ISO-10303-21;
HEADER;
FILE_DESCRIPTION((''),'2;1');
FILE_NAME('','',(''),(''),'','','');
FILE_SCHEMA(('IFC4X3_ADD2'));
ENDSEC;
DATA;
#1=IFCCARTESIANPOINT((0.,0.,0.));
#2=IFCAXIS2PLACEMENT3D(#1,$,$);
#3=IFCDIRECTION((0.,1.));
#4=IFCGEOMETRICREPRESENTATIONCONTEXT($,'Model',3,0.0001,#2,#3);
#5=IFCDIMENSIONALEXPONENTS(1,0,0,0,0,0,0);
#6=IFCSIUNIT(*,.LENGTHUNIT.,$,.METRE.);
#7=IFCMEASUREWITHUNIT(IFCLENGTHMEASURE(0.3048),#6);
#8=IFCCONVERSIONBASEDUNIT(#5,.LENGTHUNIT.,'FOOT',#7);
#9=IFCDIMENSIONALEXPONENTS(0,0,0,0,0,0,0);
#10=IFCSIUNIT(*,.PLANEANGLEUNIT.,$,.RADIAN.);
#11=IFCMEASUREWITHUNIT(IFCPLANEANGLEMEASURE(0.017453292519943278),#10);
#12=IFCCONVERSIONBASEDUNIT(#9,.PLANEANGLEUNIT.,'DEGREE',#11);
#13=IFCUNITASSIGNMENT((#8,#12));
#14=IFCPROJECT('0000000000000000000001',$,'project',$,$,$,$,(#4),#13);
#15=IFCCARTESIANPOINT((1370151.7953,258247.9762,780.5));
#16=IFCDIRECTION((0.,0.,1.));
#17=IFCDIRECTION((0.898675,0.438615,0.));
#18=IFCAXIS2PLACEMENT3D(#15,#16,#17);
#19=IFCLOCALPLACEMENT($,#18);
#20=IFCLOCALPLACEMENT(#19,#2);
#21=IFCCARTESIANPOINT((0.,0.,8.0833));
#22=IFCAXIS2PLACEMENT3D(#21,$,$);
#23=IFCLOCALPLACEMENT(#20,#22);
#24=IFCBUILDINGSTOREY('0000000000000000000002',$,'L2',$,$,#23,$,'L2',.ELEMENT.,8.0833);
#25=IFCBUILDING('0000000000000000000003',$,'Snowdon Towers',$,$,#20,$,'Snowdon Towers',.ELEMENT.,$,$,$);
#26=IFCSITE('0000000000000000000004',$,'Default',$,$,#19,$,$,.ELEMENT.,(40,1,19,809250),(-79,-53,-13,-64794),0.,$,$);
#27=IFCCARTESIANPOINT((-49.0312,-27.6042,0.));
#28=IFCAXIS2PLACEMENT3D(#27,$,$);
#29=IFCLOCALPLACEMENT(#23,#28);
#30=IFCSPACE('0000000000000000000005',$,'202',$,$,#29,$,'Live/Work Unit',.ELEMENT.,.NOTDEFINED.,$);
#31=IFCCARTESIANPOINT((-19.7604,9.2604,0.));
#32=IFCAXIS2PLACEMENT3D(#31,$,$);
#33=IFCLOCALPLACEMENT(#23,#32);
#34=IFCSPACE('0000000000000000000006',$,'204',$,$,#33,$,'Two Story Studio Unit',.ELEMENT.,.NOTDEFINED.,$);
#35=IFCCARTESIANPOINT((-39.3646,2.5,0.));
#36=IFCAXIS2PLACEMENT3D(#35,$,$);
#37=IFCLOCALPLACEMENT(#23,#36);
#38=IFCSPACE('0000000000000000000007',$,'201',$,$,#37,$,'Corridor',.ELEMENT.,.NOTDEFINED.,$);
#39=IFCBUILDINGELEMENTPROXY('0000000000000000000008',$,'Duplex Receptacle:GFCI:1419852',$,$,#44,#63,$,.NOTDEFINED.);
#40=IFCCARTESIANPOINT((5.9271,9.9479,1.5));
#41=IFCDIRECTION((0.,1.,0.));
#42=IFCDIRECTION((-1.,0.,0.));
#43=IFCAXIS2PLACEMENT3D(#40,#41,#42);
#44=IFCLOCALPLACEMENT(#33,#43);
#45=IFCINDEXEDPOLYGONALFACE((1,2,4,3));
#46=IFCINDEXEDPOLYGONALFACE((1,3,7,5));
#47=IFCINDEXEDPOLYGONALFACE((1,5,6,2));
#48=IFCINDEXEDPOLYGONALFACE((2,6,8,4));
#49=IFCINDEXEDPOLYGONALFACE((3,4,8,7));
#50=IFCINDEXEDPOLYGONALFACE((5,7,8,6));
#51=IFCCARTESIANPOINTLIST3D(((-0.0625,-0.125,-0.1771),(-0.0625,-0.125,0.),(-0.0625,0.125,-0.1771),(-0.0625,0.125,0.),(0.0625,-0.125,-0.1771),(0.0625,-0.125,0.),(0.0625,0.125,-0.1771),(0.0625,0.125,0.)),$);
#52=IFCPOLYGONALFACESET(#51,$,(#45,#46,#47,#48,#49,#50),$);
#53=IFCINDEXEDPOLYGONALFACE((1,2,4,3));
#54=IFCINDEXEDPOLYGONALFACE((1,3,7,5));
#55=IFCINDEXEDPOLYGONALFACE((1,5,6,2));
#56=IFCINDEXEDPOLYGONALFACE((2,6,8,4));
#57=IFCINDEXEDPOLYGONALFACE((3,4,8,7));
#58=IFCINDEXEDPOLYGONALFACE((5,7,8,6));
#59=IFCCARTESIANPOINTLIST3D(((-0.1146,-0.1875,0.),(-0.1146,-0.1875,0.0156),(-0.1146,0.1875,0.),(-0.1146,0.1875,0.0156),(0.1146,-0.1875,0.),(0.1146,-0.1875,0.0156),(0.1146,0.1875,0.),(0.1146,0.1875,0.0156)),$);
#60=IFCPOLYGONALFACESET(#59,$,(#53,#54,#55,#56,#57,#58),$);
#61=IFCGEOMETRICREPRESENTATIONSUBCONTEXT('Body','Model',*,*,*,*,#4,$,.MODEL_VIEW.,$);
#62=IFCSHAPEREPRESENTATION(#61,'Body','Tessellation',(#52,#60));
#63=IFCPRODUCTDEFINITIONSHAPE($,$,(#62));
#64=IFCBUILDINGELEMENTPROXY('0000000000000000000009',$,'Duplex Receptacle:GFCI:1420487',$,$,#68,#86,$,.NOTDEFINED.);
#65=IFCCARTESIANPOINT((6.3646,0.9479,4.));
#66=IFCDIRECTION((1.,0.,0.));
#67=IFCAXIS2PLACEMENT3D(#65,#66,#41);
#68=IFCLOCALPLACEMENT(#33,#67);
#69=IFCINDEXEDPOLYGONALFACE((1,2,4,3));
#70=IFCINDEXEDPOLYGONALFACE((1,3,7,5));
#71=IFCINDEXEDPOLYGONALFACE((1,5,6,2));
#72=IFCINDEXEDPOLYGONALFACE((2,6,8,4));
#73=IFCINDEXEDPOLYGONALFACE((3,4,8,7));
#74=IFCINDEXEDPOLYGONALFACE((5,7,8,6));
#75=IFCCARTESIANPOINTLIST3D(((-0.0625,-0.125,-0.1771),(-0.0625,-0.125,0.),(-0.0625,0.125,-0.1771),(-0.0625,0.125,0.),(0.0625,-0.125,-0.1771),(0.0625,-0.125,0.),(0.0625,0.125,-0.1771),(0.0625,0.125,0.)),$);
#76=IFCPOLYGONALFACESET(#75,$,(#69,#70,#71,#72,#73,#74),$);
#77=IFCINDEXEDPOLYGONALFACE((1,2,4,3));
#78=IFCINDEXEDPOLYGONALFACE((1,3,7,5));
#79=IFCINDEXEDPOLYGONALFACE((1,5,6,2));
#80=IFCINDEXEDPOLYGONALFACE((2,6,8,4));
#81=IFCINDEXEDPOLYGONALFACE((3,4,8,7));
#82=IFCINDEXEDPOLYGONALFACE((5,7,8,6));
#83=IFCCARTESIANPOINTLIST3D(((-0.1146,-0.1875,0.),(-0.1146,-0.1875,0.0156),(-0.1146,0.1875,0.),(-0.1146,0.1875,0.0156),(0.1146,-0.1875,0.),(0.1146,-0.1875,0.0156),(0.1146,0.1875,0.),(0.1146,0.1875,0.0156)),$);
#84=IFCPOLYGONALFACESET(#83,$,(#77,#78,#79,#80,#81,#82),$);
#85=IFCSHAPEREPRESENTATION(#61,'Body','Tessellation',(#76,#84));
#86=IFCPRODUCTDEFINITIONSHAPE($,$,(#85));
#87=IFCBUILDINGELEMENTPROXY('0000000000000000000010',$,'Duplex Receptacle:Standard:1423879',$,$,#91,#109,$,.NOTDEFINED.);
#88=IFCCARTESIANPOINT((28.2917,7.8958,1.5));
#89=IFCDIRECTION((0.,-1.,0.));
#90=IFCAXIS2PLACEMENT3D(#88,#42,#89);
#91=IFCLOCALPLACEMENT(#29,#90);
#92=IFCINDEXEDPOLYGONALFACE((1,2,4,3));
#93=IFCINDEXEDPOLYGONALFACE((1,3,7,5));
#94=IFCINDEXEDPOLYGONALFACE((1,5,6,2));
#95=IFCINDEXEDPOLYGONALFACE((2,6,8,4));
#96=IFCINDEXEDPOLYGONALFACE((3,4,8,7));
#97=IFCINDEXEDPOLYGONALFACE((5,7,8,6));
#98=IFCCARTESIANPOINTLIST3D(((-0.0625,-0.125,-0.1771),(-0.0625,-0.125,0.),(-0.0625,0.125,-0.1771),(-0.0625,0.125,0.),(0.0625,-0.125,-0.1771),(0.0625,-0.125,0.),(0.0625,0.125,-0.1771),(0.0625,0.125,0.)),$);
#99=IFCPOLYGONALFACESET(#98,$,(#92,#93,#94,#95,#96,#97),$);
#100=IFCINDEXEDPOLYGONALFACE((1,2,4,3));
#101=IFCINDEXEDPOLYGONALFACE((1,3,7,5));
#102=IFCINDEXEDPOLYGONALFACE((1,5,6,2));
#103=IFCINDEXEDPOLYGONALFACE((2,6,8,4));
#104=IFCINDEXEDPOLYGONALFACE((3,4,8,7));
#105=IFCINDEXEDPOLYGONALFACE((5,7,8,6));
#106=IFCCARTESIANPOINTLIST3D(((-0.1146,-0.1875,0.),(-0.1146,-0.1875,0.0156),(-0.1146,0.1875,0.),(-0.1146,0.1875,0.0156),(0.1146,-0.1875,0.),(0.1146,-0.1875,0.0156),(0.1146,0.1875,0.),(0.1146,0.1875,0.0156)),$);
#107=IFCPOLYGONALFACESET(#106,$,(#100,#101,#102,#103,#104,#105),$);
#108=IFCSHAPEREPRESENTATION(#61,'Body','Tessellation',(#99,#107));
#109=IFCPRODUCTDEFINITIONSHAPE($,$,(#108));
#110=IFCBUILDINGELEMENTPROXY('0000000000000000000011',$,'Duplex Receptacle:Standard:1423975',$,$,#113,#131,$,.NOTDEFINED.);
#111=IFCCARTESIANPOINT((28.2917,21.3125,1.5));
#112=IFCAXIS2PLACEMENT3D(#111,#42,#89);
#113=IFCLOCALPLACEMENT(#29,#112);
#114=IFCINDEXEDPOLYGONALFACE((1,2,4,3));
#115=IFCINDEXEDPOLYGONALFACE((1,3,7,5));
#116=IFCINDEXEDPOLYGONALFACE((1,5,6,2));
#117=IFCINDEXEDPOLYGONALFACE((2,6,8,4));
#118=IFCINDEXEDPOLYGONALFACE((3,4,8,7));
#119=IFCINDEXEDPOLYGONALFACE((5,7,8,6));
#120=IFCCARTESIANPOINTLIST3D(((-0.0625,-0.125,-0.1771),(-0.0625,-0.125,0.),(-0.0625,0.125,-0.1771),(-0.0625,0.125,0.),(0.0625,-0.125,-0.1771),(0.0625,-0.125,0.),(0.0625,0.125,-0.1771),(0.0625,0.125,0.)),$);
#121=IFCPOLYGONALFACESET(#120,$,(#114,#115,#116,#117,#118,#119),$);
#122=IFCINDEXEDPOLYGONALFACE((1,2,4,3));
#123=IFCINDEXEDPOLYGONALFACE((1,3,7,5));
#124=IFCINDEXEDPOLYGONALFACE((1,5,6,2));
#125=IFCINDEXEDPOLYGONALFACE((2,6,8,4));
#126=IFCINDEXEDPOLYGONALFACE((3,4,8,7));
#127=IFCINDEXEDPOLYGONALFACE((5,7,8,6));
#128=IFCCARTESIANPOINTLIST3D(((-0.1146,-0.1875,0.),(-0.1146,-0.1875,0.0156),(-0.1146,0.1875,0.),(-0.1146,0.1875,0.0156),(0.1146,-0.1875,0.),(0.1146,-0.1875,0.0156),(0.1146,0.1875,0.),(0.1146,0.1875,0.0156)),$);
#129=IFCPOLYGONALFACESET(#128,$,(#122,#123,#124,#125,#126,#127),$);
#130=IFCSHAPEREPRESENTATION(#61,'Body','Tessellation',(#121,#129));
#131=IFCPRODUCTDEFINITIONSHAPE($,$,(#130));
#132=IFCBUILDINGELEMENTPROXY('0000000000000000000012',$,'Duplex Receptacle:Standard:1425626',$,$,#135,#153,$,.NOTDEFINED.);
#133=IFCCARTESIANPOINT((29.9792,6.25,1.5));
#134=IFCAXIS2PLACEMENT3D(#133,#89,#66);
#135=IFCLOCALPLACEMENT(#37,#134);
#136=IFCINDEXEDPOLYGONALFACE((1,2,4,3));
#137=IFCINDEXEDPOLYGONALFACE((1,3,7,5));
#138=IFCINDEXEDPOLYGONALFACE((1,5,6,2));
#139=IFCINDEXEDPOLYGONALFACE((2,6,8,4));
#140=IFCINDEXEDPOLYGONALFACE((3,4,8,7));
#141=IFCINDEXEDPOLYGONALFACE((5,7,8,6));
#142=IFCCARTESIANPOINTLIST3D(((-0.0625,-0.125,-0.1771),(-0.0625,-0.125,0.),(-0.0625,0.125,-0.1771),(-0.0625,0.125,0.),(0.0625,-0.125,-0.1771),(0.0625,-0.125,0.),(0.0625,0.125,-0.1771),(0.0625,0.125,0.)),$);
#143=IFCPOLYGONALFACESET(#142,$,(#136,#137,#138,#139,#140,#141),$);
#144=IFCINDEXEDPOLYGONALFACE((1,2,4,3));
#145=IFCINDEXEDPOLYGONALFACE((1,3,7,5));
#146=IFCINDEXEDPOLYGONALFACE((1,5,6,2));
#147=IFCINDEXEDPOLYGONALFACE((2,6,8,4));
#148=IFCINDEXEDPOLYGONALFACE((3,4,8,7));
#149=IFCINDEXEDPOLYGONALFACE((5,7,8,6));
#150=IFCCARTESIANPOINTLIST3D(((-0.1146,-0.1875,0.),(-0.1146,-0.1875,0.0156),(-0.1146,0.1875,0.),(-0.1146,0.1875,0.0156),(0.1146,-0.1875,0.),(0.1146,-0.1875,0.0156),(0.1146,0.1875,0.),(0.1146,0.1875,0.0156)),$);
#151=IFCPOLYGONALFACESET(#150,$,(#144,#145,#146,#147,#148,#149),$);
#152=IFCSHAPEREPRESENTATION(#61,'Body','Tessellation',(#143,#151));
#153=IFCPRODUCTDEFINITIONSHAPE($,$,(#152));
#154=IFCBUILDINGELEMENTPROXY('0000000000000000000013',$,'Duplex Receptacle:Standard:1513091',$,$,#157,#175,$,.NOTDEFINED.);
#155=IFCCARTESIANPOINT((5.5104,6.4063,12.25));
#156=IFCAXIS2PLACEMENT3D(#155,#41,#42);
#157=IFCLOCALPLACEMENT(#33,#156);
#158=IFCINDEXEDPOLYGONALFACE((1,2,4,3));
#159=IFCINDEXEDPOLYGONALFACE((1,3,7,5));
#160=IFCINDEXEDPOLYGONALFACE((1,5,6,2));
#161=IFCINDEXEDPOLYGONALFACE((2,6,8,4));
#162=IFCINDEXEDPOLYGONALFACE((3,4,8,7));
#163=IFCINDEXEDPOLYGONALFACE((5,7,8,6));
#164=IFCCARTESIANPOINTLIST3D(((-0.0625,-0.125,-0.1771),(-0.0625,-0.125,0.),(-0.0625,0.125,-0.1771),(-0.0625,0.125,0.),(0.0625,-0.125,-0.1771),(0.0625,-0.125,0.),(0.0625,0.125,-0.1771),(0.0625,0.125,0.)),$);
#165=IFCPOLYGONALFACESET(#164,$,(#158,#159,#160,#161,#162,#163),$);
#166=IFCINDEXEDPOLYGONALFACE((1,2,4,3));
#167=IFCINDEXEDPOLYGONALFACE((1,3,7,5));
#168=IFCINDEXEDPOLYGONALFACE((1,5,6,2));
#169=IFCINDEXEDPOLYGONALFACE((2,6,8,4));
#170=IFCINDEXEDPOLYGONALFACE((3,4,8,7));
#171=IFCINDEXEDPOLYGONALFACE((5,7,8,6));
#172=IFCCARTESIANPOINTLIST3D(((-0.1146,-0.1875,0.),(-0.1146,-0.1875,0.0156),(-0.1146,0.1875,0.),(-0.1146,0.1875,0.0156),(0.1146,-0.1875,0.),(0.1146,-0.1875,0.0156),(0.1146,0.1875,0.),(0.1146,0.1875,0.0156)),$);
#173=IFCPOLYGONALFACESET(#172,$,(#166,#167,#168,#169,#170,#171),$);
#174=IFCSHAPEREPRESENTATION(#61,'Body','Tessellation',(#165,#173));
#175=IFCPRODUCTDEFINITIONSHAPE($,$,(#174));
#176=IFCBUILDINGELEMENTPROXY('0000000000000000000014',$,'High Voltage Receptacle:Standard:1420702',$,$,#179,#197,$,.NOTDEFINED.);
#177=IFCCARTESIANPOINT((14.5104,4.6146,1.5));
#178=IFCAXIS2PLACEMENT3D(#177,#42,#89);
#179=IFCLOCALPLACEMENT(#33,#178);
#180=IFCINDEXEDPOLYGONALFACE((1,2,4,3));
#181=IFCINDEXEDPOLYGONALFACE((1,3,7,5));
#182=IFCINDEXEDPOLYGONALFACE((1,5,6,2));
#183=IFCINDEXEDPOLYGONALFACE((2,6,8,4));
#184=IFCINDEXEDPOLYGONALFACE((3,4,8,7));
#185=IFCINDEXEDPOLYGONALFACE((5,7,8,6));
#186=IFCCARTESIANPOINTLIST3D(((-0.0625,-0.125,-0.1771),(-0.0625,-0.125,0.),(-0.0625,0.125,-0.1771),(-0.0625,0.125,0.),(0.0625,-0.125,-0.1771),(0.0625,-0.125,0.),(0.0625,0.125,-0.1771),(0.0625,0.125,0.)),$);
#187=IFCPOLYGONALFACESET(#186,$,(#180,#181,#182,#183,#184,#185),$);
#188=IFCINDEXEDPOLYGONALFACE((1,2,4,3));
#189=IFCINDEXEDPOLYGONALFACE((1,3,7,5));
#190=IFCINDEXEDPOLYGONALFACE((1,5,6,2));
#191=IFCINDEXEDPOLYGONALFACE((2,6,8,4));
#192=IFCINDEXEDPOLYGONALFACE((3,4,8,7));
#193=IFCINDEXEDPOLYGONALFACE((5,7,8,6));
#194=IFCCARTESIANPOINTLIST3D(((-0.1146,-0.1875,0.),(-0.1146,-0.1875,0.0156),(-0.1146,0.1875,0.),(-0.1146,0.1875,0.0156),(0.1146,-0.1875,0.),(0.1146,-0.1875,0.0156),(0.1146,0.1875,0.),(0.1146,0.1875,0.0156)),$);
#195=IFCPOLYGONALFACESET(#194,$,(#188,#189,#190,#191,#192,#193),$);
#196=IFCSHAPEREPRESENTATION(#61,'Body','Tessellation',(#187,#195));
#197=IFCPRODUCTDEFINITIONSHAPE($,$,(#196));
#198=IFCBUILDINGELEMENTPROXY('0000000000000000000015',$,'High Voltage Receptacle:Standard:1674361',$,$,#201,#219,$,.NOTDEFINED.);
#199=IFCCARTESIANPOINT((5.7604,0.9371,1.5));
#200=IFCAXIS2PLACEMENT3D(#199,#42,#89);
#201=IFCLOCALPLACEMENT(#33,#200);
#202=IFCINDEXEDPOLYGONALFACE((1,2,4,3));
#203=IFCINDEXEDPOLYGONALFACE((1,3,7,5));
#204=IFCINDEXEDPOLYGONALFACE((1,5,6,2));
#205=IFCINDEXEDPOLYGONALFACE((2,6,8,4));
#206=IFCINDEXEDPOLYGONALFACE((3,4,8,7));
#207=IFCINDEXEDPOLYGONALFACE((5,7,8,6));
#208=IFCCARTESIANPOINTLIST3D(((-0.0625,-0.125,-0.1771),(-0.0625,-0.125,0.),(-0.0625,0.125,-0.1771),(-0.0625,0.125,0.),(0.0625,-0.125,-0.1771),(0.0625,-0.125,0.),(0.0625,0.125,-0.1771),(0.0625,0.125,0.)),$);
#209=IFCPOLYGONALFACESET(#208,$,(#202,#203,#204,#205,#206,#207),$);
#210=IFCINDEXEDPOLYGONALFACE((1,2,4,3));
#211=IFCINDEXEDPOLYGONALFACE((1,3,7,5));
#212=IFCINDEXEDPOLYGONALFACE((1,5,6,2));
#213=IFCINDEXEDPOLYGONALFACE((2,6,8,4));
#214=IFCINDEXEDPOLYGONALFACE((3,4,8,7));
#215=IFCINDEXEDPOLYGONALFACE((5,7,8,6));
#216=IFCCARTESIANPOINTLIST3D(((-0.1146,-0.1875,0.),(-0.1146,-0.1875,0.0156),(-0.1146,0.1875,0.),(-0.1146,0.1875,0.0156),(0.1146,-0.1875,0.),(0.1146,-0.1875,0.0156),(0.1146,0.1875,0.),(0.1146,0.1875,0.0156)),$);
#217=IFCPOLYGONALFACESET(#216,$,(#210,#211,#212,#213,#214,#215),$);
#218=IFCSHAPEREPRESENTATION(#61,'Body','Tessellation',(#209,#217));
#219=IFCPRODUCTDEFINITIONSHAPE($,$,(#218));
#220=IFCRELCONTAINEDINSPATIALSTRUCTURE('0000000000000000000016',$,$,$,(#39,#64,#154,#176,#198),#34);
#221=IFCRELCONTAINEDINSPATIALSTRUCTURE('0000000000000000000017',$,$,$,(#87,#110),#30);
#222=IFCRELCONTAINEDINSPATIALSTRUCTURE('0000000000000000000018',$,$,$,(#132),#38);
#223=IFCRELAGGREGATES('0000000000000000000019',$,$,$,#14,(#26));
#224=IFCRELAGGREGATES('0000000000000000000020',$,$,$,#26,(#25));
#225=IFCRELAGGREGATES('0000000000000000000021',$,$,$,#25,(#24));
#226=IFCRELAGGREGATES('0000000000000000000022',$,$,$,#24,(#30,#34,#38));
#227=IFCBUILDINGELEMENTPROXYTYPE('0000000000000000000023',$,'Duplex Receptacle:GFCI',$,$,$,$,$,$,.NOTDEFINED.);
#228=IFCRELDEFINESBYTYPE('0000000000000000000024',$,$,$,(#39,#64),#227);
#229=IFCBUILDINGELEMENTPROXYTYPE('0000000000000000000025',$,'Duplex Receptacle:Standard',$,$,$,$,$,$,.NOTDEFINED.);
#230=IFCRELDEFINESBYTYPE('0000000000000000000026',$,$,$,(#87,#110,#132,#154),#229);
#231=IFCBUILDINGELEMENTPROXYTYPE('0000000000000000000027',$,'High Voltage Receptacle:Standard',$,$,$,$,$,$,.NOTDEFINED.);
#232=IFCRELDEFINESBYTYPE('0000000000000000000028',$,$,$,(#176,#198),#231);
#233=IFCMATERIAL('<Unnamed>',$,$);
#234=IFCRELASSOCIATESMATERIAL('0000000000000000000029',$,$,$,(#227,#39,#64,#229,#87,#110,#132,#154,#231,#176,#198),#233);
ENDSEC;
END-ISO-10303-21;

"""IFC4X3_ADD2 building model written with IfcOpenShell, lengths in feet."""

from ifc_helpers import new_model, entity, si_unit, converted_unit, direction, frame, frame_2d, origin, origin_2d_with_axis, place, context, subcontext, project, spatial, rectangle, extrude, source, transform, mapped, material, type_object, type_shapes, element, save


model = new_model("IFC4X3_ADD2")

# Units and contexts
model_context = context("Model", 3, precision=0.0001, world=origin(), true_north=direction((0.0, 1.0)))
body_context = subcontext(model_context, "Body", "Model", "MODEL_VIEW")
ifc_project = project(units=[converted_unit("LENGTHUNIT", "FOOT", entity("IfcLengthMeasure", 0.3048), si_unit("LENGTHUNIT", "METRE"), dimensions=[1, 0, 0, 0, 0, 0, 0]), converted_unit("PLANEANGLEUNIT", "DEGREE", entity("IfcPlaneAngleMeasure", 0.017453292519943278), si_unit("PLANEANGLEUNIT", "RADIAN"), dimensions=[0, 0, 0, 0, 0, 0, 0])], contexts=[model_context])

# Site, building, storey, space
site_placement = place(None, frame((1370151.7953, 258247.9762, 780.5), z_axis=(0.0, 0.0, 1.0), x_axis=(0.898675, 0.438615, 0.0)))
site = spatial("IfcSite", under=ifc_project, at=site_placement, Name="Default", CompositionType="ELEMENT", RefLatitude=(40, 1, 19, 809250), RefLongitude=(-79, -53, -13, -64794), RefElevation=0.0)
building_placement = place(site_placement, origin())
building = spatial("IfcBuilding", under=site, at=building_placement, Name="Snowdon Towers", LongName="Snowdon Towers", CompositionType="ELEMENT")
storey_placement = place(building_placement, frame((0.0, 0.0, 8.0833)))
storey = spatial("IfcBuildingStorey", under=building, at=storey_placement, Name="L2", LongName="L2", CompositionType="ELEMENT", Elevation=8.0833)
space_1_placement = place(storey_placement, frame((-49.0312, -27.6042, 0.0)))
space_1 = spatial("IfcSpace", under=storey, at=space_1_placement, Name="202", LongName="Live/Work Unit", CompositionType="ELEMENT", PredefinedType="NOTDEFINED")

# Shared definitions
ifc_material_1 = material(Name="<Unnamed>")

# Shared definitions
space_2_placement = place(storey_placement, frame((-19.7604, 9.2604, 0.0)))
space_2 = spatial("IfcSpace", under=storey, at=space_2_placement, Name="204", LongName="Two Story Studio Unit", CompositionType="ELEMENT", PredefinedType="NOTDEFINED")

# Building element proxies
building_element_proxy_type_1 = type_object("IfcBuildingElementProxyType", Name="Duplex Receptacle:GFCI", PredefinedType="NOTDEFINED", material=ifc_material_1)
shared_shape_1 = source(origin(), body_context, "Body", "SweptSolid", [
    extrude(rectangle(XDim=0.125, YDim=0.25, at=origin_2d_with_axis()), frame((0.0, 0.0, -0.1771), z_axis=(0.0, 0.0, 1.0), x_axis=(-1.0, 0.0, 0.0)), (0.0, 0.0, 1.0), 0.1771),
    extrude(rectangle(XDim=0.2292, YDim=0.375, at=frame_2d((0.0, 0.0), x_axis=(1.0, 0.0))), frame((0.0, 0.0, 0.0), z_axis=(0.0, 0.0, 1.0), x_axis=(-1.0, 0.0, 0.0)), (0.0, 0.0, 1.0), 0.0156),
])
type_shapes(building_element_proxy_type_1, [shared_shape_1])
for number, where, z_axis, x_axis, name in (
    (1, (5.9271, 9.9479, 1.5), (0.0, 1.0, 0.0), (-1.0, 0.0, 0.0), "Duplex Receptacle:GFCI:1419852"),
    (2, (6.3646, 0.9479, 4.0), (1.0, 0.0, 0.0), (0.0, 1.0, 0.0), "Duplex Receptacle:GFCI:1420487"),
):
    element("IfcBuildingElementProxy", number, at=place(space_2_placement, frame(where, z_axis=z_axis, x_axis=x_axis)), inside=space_2, type_object=building_element_proxy_type_1, material=ifc_material_1, Name=name, PredefinedType="NOTDEFINED", context=body_context, shape_type="MappedRepresentation", body=[
        mapped(shared_shape_1, transform((0.0, 0.0, 0.0), scale=1.0)),
    ])
building_element_proxy_type_2 = type_object("IfcBuildingElementProxyType", Name="Duplex Receptacle:Standard", PredefinedType="NOTDEFINED", material=ifc_material_1)
shared_shape_2 = source(origin(), body_context, "Body", "SweptSolid", [
    extrude(rectangle(XDim=0.125, YDim=0.25, at=origin_2d_with_axis()), frame((0.0, 0.0, -0.1771), z_axis=(0.0, 0.0, 1.0), x_axis=(-1.0, 0.0, 0.0)), (0.0, 0.0, 1.0), 0.1771),
    extrude(rectangle(XDim=0.2292, YDim=0.375, at=frame_2d((0.0, 0.0), x_axis=(1.0, 0.0))), frame((0.0, 0.0, 0.0), z_axis=(0.0, 0.0, 1.0), x_axis=(-1.0, 0.0, 0.0)), (0.0, 0.0, 1.0), 0.0156),
])
type_shapes(building_element_proxy_type_2, [shared_shape_2])
for number, where, z_axis, x_axis, name in (
    (3, (28.2917, 7.8958, 1.5), (-1.0, 0.0, 0.0), (0.0, -1.0, 0.0), "Duplex Receptacle:Standard:1423879"),
    (4, (28.2917, 21.3125, 1.5), (-1.0, 0.0, 0.0), (0.0, -1.0, 0.0), "Duplex Receptacle:Standard:1423975"),
):
    element("IfcBuildingElementProxy", number, at=place(space_1_placement, frame(where, z_axis=z_axis, x_axis=x_axis)), inside=space_1, type_object=building_element_proxy_type_2, material=ifc_material_1, Name=name, PredefinedType="NOTDEFINED", context=body_context, shape_type="MappedRepresentation", body=[
        mapped(shared_shape_2, transform((0.0, 0.0, 0.0), scale=1.0)),
    ])

# Shared definitions
space_3_placement = place(storey_placement, frame((-39.3646, 2.5, 0.0)))
space_3 = spatial("IfcSpace", under=storey, at=space_3_placement, Name="201", LongName="Corridor", CompositionType="ELEMENT", PredefinedType="NOTDEFINED")

# Building element proxies
proxy_1_placement = place(space_3_placement, frame((29.9792, 6.25, 1.5), z_axis=(0.0, -1.0, 0.0), x_axis=(1.0, 0.0, 0.0)))
element("IfcBuildingElementProxy", 5, at=proxy_1_placement, inside=space_3, type_object=building_element_proxy_type_2, material=ifc_material_1, Name="Duplex Receptacle:Standard:1425626", PredefinedType="NOTDEFINED", context=body_context, shape_type="MappedRepresentation", body=[
    mapped(shared_shape_2, transform((0.0, 0.0, 0.0), scale=1.0)),
])
for number, where, z_axis, x_axis, name in (
    (6, (5.5104, 6.4063, 12.25), (0.0, 1.0, 0.0), (-1.0, 0.0, 0.0), "Duplex Receptacle:Standard:1513091"),
):
    element("IfcBuildingElementProxy", number, at=place(space_2_placement, frame(where, z_axis=z_axis, x_axis=x_axis)), inside=space_2, type_object=building_element_proxy_type_2, material=ifc_material_1, Name=name, PredefinedType="NOTDEFINED", context=body_context, shape_type="MappedRepresentation", body=[
        mapped(shared_shape_2, transform((0.0, 0.0, 0.0), scale=1.0)),
    ])
building_element_proxy_type_3 = type_object("IfcBuildingElementProxyType", Name="High Voltage Receptacle:Standard", PredefinedType="NOTDEFINED", material=ifc_material_1)
shared_shape_3 = source(origin(), body_context, "Body", "SweptSolid", [
    extrude(rectangle(XDim=0.125, YDim=0.25, at=origin_2d_with_axis()), frame((0.0, 0.0, -0.1771), z_axis=(0.0, 0.0, 1.0), x_axis=(-1.0, 0.0, 0.0)), (0.0, 0.0, 1.0), 0.1771),
    extrude(rectangle(XDim=0.2292, YDim=0.375, at=frame_2d((0.0, 0.0), x_axis=(1.0, 0.0))), frame((0.0, 0.0, 0.0), z_axis=(0.0, 0.0, 1.0), x_axis=(-1.0, 0.0, 0.0)), (0.0, 0.0, 1.0), 0.0156),
])
type_shapes(building_element_proxy_type_3, [shared_shape_3])
for number, where, z_axis, x_axis, name in (
    (7, (14.5104, 4.6146, 1.5), (-1.0, 0.0, 0.0), (0.0, -1.0, 0.0), "High Voltage Receptacle:Standard:1420702"),
    (8, (5.7604, 0.9371, 1.5), (-1.0, 0.0, 0.0), (0.0, -1.0, 0.0), "High Voltage Receptacle:Standard:1674361"),
):
    element("IfcBuildingElementProxy", number, at=place(space_2_placement, frame(where, z_axis=z_axis, x_axis=x_axis)), inside=space_2, type_object=building_element_proxy_type_3, material=ifc_material_1, Name=name, PredefinedType="NOTDEFINED", context=body_context, shape_type="MappedRepresentation", body=[
        mapped(shared_shape_3, transform((0.0, 0.0, 0.0), scale=1.0)),
    ])

save(model, "model.ifc")
